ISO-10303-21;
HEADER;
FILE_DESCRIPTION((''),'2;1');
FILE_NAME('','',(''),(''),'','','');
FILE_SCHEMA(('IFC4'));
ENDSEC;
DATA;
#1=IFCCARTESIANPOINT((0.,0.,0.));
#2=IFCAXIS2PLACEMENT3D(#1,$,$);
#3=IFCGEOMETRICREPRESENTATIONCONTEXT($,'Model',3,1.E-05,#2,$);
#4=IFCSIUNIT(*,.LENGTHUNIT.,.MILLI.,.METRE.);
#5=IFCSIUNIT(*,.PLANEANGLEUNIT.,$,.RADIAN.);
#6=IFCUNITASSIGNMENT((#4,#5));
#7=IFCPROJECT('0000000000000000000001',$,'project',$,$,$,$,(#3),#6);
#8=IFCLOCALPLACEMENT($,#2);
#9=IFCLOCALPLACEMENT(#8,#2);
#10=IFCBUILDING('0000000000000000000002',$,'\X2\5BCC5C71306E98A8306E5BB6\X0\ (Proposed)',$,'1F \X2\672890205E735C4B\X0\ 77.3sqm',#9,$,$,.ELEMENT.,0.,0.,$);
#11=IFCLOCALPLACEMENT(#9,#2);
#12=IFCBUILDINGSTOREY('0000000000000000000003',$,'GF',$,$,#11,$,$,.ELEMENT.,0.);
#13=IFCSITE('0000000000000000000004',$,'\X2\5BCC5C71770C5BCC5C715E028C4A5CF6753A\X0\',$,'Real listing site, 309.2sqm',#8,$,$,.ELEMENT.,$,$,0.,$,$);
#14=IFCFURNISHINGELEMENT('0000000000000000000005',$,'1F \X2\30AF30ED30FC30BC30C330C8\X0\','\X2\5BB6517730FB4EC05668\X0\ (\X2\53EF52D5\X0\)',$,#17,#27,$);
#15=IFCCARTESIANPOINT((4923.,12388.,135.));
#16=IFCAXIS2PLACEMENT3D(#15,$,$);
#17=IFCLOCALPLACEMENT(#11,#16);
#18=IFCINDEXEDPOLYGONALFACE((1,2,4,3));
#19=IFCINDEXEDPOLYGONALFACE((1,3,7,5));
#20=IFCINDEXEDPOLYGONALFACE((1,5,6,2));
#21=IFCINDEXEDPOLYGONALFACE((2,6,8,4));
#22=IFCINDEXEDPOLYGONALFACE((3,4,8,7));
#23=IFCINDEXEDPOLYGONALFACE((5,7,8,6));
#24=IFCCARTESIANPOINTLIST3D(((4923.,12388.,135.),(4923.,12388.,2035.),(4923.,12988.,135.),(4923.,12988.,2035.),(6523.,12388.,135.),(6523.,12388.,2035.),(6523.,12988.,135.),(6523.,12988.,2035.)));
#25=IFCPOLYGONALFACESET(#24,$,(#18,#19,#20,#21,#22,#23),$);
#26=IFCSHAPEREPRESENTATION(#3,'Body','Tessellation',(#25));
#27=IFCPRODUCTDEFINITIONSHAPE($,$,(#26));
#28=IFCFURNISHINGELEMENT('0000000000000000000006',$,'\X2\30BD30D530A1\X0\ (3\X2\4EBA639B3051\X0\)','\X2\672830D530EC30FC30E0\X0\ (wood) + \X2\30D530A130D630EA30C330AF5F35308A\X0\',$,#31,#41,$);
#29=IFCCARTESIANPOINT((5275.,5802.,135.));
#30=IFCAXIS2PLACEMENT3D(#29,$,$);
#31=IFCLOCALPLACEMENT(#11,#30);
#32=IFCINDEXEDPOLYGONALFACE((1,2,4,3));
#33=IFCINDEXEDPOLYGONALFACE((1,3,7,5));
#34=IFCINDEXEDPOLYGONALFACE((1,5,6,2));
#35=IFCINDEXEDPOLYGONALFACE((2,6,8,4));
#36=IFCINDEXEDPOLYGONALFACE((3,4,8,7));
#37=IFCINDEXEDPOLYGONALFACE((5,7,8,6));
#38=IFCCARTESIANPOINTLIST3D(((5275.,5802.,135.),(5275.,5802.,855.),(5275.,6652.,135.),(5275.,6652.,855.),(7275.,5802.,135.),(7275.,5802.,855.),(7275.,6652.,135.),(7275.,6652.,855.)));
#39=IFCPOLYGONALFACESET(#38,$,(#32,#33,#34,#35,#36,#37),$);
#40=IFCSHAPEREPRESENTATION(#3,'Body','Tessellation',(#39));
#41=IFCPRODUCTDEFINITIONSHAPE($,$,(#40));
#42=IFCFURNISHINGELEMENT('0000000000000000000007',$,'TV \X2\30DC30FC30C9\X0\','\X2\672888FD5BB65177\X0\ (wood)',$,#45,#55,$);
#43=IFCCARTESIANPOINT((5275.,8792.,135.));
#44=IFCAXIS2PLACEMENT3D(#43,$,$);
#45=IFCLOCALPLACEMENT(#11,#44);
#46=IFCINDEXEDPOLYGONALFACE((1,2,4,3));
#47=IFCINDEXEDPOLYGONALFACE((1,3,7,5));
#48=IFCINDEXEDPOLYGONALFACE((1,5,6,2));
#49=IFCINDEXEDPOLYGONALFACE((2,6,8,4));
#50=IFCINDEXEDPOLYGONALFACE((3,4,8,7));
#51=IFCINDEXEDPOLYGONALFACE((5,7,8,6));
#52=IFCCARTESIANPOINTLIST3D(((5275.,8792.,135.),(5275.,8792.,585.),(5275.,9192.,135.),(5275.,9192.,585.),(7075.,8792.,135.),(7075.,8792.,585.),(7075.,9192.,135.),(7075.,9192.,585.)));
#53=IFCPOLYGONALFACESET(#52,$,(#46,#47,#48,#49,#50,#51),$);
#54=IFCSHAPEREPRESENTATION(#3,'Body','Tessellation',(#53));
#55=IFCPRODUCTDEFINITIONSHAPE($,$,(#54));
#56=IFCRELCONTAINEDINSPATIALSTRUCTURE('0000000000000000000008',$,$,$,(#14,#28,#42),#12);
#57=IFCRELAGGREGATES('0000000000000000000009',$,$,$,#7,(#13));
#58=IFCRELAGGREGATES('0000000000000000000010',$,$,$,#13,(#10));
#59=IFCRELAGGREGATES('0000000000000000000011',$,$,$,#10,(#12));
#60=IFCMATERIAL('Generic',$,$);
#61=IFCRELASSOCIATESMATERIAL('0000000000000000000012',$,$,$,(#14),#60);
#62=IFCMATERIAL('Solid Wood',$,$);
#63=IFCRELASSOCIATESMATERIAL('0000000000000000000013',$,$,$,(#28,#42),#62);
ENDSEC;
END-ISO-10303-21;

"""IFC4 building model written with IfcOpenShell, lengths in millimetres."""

from ifc_helpers import new_model, si_unit, frame, frame_2d, origin, place, context, project, spatial, rectangle, extrude, material, element, save


model = new_model("IFC4")

# Units and contexts
model_context = context("Model", 3, precision=1e-05, world=origin())
ifc_project = project(units=[si_unit("LENGTHUNIT", "METRE", prefix="MILLI"), si_unit("PLANEANGLEUNIT", "RADIAN")], contexts=[model_context])

# Site, building, storey
site_placement = place(None, origin())
site = spatial("IfcSite", under=ifc_project, at=site_placement, Name="富山県富山市豊島町", ObjectType="Real listing site, 309.2sqm", CompositionType="ELEMENT", RefElevation=0.0)
building_placement = place(site_placement, origin())
building = spatial("IfcBuilding", under=site, at=building_placement, Name="富山の風の家 (Proposed)", ObjectType="1F 木造平屋 77.3sqm", CompositionType="ELEMENT", ElevationOfRefHeight=0.0, ElevationOfTerrain=0.0)
storey_placement = place(building_placement, origin())
storey = spatial("IfcBuildingStorey", under=building, at=storey_placement, Name="GF", CompositionType="ELEMENT", Elevation=0.0)

# Shared definitions
ifc_material_1 = material(Name="Solid Wood")

# Shared definitions
ifc_material_2 = material(Name="Generic")

# Furnishing elements
furnishing_1_placement = place(storey_placement, frame((4923.0, 12388.0, 135.0)))
element("IfcFurnishingElement", 1, at=furnishing_1_placement, inside=storey, material=ifc_material_2, Name="1F クローゼット", Description="家具・什器 (可動)", context=model_context, shape_type="SweptSolid", body=[
    extrude(rectangle(XDim=1600.0, YDim=600.0, at=frame_2d((800.0, 300.0))), frame((4923.0, 12388.0, 135.0)), (0.0, 0.0, 1.0), 1900.0),
])
furnishing_2_placement = place(storey_placement, frame((5275.0, 5802.0, 135.0)))
element("IfcFurnishingElement", 2, at=furnishing_2_placement, inside=storey, material=ifc_material_1, Name="ソファ (3人掛け)", Description="木フレーム (wood) + ファブリック張り", context=model_context, shape_type="SweptSolid", body=[
    extrude(rectangle(XDim=2000.0, YDim=850.0, at=frame_2d((1000.0, 425.0))), frame((5275.0, 5802.0, 135.0)), (0.0, 0.0, 1.0), 720.0),
])
furnishing_3_placement = place(storey_placement, frame((5275.0, 8792.0, 135.0)))
element("IfcFurnishingElement", 3, at=furnishing_3_placement, inside=storey, material=ifc_material_1, Name="TV ボード", Description="木製家具 (wood)", context=model_context, shape_type="SweptSolid", body=[
    extrude(rectangle(XDim=1800.0, YDim=400.0, at=frame_2d((900.0, 200.0))), frame((5275.0, 8792.0, 135.0)), (0.0, 0.0, 1.0), 450.0),
])

save(model, "model.ifc")
